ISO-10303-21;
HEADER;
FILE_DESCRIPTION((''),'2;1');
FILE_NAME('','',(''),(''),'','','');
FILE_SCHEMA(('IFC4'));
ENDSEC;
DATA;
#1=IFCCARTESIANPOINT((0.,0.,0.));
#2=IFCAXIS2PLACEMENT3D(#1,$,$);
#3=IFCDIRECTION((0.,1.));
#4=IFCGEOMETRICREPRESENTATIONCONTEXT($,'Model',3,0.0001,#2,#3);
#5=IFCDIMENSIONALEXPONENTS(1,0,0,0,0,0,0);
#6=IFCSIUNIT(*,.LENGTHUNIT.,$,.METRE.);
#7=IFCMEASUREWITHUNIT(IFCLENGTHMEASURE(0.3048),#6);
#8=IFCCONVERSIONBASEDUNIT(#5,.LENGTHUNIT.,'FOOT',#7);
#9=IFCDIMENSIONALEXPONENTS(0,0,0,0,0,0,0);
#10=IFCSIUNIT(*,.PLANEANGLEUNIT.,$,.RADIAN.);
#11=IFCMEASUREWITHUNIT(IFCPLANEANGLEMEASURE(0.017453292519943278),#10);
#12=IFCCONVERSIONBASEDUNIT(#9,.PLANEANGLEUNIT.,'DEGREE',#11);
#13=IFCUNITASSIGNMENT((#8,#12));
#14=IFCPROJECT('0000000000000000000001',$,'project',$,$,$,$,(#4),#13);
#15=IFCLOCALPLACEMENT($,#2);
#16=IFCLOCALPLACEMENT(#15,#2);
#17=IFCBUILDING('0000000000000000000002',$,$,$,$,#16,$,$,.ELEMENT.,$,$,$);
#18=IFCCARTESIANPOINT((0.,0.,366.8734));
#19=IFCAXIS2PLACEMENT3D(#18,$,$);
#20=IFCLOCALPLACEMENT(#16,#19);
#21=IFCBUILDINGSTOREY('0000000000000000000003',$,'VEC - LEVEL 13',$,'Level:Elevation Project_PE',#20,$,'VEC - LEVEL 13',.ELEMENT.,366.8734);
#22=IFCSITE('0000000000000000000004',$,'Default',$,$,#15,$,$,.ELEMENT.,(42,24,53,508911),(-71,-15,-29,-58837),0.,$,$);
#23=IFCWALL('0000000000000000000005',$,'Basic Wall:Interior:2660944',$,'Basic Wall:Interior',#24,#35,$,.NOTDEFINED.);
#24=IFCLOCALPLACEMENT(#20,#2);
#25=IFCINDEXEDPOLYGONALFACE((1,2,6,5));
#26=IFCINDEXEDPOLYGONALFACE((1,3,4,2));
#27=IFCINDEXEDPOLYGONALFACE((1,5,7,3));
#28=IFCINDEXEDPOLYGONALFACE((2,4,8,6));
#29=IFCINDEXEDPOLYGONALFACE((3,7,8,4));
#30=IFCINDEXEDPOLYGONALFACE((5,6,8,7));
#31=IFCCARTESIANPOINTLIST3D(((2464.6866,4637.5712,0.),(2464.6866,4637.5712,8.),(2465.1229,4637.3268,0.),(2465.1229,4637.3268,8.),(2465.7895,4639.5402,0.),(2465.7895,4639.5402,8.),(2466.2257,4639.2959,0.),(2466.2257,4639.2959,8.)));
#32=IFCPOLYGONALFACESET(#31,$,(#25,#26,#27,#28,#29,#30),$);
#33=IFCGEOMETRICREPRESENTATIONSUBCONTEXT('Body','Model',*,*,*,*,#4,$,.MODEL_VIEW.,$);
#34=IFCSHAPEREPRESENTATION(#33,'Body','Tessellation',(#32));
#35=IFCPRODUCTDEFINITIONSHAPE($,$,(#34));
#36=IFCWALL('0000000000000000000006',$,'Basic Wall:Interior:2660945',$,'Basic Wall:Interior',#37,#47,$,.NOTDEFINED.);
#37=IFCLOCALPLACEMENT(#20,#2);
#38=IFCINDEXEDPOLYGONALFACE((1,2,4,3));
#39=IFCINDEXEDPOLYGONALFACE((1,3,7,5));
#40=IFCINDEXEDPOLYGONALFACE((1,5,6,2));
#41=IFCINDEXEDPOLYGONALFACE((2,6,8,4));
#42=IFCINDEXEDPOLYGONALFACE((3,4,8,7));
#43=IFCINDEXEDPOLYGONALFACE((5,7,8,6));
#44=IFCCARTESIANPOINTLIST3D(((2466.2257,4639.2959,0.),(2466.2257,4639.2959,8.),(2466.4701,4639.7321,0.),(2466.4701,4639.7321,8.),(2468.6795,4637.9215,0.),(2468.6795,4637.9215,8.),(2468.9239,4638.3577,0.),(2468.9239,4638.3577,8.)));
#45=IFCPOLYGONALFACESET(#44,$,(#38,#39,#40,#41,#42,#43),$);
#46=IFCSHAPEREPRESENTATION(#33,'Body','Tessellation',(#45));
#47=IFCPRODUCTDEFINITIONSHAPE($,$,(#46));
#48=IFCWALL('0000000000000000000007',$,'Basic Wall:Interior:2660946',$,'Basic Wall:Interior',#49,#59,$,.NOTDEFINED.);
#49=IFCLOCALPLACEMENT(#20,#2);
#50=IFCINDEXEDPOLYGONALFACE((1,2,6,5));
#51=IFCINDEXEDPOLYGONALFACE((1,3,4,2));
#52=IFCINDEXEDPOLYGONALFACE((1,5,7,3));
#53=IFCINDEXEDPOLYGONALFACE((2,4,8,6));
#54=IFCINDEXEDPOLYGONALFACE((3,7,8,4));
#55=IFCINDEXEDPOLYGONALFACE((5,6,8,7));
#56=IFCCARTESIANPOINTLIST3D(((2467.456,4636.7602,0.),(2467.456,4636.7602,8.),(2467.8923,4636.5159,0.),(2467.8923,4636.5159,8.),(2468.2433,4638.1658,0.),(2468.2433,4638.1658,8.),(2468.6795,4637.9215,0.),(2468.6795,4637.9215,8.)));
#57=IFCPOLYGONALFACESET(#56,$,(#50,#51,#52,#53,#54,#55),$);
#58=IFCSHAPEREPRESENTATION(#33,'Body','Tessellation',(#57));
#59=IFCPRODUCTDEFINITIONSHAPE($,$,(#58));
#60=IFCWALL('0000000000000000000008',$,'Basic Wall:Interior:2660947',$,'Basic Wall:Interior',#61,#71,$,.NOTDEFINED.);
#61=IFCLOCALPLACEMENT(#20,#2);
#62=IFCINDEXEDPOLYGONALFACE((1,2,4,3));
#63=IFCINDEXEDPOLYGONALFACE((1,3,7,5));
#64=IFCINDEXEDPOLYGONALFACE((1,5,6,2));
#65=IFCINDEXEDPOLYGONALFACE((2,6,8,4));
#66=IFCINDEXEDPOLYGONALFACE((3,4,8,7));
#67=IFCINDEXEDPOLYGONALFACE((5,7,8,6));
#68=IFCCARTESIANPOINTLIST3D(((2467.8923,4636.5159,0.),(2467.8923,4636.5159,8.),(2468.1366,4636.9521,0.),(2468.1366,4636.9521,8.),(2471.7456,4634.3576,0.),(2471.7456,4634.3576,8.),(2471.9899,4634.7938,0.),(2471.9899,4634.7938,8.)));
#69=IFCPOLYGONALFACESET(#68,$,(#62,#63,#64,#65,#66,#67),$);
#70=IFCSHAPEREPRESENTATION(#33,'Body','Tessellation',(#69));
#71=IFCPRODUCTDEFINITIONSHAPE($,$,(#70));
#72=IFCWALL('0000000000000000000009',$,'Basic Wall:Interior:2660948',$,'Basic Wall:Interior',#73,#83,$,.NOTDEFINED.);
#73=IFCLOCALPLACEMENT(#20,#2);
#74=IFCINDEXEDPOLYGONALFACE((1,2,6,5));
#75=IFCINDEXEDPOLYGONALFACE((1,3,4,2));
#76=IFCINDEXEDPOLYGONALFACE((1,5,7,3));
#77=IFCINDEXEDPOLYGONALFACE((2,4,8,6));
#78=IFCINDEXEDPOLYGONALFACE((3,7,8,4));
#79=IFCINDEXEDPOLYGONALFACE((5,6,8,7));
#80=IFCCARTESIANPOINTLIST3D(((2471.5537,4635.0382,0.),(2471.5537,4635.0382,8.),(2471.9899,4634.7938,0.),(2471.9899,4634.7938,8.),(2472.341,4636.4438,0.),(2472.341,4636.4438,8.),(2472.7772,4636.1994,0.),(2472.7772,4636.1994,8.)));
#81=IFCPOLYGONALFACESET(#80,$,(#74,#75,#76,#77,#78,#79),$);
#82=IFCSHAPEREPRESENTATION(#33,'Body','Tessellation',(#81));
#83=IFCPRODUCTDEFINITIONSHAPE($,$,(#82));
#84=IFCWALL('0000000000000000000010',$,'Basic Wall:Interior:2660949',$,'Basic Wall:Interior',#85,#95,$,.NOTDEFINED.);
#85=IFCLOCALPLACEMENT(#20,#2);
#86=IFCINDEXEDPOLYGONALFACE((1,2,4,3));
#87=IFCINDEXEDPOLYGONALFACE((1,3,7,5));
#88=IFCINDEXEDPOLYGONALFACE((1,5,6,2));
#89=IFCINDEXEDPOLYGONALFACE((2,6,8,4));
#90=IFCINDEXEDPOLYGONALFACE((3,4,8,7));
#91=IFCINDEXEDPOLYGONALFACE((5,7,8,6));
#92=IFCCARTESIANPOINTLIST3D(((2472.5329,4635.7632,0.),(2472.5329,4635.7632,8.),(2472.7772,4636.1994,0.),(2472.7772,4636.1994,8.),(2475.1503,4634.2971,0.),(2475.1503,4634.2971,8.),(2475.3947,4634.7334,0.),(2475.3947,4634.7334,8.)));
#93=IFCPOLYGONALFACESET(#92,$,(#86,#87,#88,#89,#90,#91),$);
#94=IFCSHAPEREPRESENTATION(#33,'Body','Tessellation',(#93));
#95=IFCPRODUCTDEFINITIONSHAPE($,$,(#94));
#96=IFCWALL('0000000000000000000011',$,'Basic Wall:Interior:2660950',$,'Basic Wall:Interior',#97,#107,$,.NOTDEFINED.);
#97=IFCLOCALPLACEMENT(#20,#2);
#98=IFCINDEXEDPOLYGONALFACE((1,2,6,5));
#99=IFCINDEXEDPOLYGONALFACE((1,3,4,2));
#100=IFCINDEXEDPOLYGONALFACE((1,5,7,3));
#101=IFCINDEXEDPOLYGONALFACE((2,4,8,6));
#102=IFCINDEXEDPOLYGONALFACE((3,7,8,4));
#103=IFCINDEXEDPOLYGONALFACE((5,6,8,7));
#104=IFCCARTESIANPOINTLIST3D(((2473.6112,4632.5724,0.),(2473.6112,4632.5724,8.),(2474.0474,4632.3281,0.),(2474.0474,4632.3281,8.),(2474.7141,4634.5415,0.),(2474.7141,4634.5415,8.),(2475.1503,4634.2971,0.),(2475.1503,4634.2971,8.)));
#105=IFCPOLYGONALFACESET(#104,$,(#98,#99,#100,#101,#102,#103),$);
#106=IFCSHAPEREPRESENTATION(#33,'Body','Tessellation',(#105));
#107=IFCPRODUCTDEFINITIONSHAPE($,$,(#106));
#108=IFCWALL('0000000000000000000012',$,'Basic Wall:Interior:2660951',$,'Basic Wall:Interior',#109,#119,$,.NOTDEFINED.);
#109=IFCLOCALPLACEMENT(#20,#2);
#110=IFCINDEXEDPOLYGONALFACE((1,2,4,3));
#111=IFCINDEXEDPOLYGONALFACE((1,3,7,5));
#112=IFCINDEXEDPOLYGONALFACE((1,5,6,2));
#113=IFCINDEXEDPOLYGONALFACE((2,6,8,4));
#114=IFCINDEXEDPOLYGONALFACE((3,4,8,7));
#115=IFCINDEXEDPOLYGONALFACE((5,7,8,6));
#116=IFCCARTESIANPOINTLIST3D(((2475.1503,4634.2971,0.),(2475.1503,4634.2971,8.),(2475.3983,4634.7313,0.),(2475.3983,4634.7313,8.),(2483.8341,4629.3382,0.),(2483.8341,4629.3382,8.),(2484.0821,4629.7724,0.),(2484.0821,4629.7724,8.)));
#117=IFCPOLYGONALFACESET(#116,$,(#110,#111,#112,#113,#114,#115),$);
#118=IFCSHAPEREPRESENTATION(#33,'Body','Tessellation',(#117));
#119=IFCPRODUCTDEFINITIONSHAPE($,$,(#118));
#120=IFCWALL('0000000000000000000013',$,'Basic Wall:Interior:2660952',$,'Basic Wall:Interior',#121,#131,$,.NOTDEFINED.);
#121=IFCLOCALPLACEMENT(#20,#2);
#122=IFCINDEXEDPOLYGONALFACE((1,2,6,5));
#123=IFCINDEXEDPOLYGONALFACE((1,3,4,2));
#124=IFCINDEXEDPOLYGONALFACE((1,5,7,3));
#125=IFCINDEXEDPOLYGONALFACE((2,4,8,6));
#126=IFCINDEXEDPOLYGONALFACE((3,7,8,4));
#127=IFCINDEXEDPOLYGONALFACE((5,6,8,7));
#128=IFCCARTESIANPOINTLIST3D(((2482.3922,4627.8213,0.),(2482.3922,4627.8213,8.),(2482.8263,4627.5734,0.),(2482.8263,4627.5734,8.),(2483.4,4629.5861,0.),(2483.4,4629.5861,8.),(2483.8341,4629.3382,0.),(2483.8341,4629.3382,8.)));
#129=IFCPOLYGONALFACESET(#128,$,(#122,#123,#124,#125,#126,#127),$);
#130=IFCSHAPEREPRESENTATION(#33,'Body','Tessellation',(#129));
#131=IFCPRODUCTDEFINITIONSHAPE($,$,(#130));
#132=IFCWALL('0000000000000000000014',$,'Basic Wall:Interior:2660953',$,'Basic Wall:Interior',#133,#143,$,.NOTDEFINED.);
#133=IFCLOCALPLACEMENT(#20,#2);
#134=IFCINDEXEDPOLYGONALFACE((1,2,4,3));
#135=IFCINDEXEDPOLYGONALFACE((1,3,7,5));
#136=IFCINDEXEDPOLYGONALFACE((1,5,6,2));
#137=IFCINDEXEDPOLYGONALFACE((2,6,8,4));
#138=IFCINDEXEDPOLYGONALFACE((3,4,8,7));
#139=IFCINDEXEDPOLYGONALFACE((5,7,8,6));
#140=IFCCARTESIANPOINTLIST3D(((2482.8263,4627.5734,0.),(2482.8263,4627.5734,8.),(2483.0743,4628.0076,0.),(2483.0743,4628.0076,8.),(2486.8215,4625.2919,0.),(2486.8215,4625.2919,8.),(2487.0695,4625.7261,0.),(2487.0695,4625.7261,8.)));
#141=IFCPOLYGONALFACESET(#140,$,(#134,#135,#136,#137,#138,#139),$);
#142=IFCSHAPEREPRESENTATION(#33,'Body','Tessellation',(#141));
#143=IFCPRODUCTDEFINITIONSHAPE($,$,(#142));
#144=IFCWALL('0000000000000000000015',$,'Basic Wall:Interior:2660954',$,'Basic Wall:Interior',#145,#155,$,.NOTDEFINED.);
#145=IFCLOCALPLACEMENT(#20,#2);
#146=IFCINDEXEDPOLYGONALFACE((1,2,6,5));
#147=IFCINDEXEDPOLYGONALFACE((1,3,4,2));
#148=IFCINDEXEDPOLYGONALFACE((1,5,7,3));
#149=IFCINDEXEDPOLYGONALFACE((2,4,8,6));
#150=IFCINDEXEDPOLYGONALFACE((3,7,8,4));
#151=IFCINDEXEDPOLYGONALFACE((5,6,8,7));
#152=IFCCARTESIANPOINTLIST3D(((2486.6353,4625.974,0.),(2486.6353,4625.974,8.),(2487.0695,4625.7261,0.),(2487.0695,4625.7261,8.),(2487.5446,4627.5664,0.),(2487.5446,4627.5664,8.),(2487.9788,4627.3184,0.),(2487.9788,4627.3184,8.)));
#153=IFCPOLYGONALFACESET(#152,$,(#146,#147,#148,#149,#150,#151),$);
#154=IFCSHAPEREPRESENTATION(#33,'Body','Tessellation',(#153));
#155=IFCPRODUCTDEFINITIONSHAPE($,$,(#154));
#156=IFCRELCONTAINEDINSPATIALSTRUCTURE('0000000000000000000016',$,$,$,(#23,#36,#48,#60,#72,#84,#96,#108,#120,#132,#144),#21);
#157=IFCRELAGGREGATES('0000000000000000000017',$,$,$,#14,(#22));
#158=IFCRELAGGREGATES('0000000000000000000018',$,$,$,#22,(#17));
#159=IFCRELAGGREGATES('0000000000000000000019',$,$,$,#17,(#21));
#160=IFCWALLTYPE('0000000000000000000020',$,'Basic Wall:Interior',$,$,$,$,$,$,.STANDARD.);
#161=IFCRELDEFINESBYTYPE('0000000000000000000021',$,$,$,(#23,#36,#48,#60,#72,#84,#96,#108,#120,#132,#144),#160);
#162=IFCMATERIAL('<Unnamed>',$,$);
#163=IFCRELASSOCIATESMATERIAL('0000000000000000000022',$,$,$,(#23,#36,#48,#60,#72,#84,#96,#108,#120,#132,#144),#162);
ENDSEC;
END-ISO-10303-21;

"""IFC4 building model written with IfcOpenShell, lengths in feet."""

from ifc_helpers import new_model, entity, si_unit, converted_unit, direction, frame, origin, place, context, subcontext, project, spatial, indexed_curve, outline, extrude, material, type_object, element, save


model = new_model("IFC4")

# Units and contexts
model_context = context("Model", 3, precision=0.0001, world=origin(), true_north=direction((0.0, 1.0)))
body_context = subcontext(model_context, "Body", "Model", "MODEL_VIEW")
ifc_project = project(units=[converted_unit("LENGTHUNIT", "FOOT", entity("IfcLengthMeasure", 0.3048), si_unit("LENGTHUNIT", "METRE"), dimensions=[1, 0, 0, 0, 0, 0, 0]), converted_unit("PLANEANGLEUNIT", "DEGREE", entity("IfcPlaneAngleMeasure", 0.017453292519943278), si_unit("PLANEANGLEUNIT", "RADIAN"), dimensions=[0, 0, 0, 0, 0, 0, 0])], contexts=[model_context])

# Site, building, storey
site_placement = place(None, origin())
site = spatial("IfcSite", under=ifc_project, at=site_placement, Name="Default", CompositionType="ELEMENT", RefLatitude=(42, 24, 53, 508911), RefLongitude=(-71, -15, -29, -58837), RefElevation=0.0)
building_placement = place(site_placement, origin())
building = spatial("IfcBuilding", under=site, at=building_placement, CompositionType="ELEMENT")
storey_placement = place(building_placement, frame((0.0, 0.0, 366.8734)))
storey = spatial("IfcBuildingStorey", under=building, at=storey_placement, Name="VEC - LEVEL 13", ObjectType="Level:Elevation Project_PE", LongName="VEC - LEVEL 13", CompositionType="ELEMENT", Elevation=366.8734)

# Walls
ifc_material_1 = material(Name="<Unnamed>")
wall_type = type_object("IfcWallType", Name="Basic Wall:Interior", PredefinedType="STANDARD")
wall_1_placement = place(storey_placement, frame((2466.0076, 4639.418, 0.0), z_axis=(0.0, 0.0, 1.0), x_axis=(-0.488675, -0.872466, 0.0)))
element("IfcWall", 1, at=wall_1_placement, inside=storey, type_object=wall_type, material=ifc_material_1, Name="Basic Wall:Interior:2660944", ObjectType="Basic Wall:Interior", PredefinedType="NOTDEFINED", context=body_context, shape_type="SweptSolid", body=[
    extrude(outline(indexed_curve([(2.2569, 0.25), (0.0, 0.25), (0.0, -0.25), (2.2569, -0.25), (2.2569, 0.25)], self_intersect=False)), origin(), (0.0, 0.0, 1.0), 8.0),
])
wall_2_placement = place(storey_placement, frame((2466.3479, 4639.514, 0.0), z_axis=(0.0, 0.0, 1.0), x_axis=(0.872466, -0.488675, 0.0)))
element("IfcWall", 2, at=wall_2_placement, inside=storey, type_object=wall_type, material=ifc_material_1, Name="Basic Wall:Interior:2660945", ObjectType="Basic Wall:Interior", PredefinedType="NOTDEFINED", context=body_context, shape_type="SweptSolid", body=[
    extrude(outline(indexed_curve([(2.8125, 0.25), (0.0, 0.25), (0.0, -0.25), (2.8125, -0.25), (2.8125, 0.25)], self_intersect=False)), origin(), (0.0, 0.0, 1.0), 8.0),
])
wall_3_placement = place(storey_placement, frame((2468.4614, 4638.0436, 0.0), z_axis=(0.0, 0.0, 1.0), x_axis=(-0.488675, -0.872466, 0.0)))
element("IfcWall", 3, at=wall_3_placement, inside=storey, type_object=wall_type, material=ifc_material_1, Name="Basic Wall:Interior:2660946", ObjectType="Basic Wall:Interior", PredefinedType="NOTDEFINED", context=body_context, shape_type="SweptSolid", body=[
    extrude(outline(indexed_curve([(1.611, 0.25), (0.0, 0.25), (0.0, -0.25), (1.611, -0.25), (1.611, 0.25)], self_intersect=False)), origin(), (0.0, 0.0, 1.0), 8.0),
])
wall_4_placement = place(storey_placement, frame((2468.0144, 4636.734, 0.0), z_axis=(0.0, 0.0, 1.0), x_axis=(0.872466, -0.488675, 0.0)))
element("IfcWall", 4, at=wall_4_placement, inside=storey, type_object=wall_type, material=ifc_material_1, Name="Basic Wall:Interior:2660947", ObjectType="Basic Wall:Interior", PredefinedType="NOTDEFINED", context=body_context, shape_type="SweptSolid", body=[
    extrude(outline(indexed_curve([(4.4166, 0.25), (0.0, 0.25), (0.0, -0.25), (4.4166, -0.25), (4.4166, 0.25)], self_intersect=False)), origin(), (0.0, 0.0, 1.0), 8.0),
])
wall_5_placement = place(storey_placement, frame((2471.7718, 4634.916, 0.0), z_axis=(0.0, 0.0, 1.0), x_axis=(0.488675, 0.872466, 0.0)))
element("IfcWall", 5, at=wall_5_placement, inside=storey, type_object=wall_type, material=ifc_material_1, Name="Basic Wall:Interior:2660948", ObjectType="Basic Wall:Interior", PredefinedType="NOTDEFINED", context=body_context, shape_type="SweptSolid", body=[
    extrude(outline(indexed_curve([(1.611, 0.25), (0.0, 0.25), (0.0, -0.25), (1.611, -0.25), (1.611, 0.25)], self_intersect=False)), origin(), (0.0, 0.0, 1.0), 8.0),
])
wall_6_placement = place(storey_placement, frame((2472.655, 4635.9813, 0.0), z_axis=(0.0, 0.0, 1.0), x_axis=(0.872466, -0.488675, 0.0)))
element("IfcWall", 6, at=wall_6_placement, inside=storey, type_object=wall_type, material=ifc_material_1, Name="Basic Wall:Interior:2660949", ObjectType="Basic Wall:Interior", PredefinedType="NOTDEFINED", context=body_context, shape_type="SweptSolid", body=[
    extrude(outline(indexed_curve([(3.0001, 0.25), (0.0, 0.25), (0.0, -0.25), (3.0001, -0.25), (3.0001, 0.25)], self_intersect=False)), origin(), (0.0, 0.0, 1.0), 8.0),
])
wall_7_placement = place(storey_placement, frame((2474.9322, 4634.4193, 0.0), z_axis=(0.0, 0.0, 1.0), x_axis=(-0.488675, -0.872466, 0.0)))
element("IfcWall", 7, at=wall_7_placement, inside=storey, type_object=wall_type, material=ifc_material_1, Name="Basic Wall:Interior:2660950", ObjectType="Basic Wall:Interior", PredefinedType="NOTDEFINED", context=body_context, shape_type="SweptSolid", body=[
    extrude(outline(indexed_curve([(2.2569, 0.25), (0.0, 0.25), (0.0, -0.25), (2.2569, -0.25), (2.2569, 0.25)], self_intersect=False)), origin(), (0.0, 0.0, 1.0), 8.0),
])
wall_8_placement = place(storey_placement, frame((2475.2743, 4634.5142, 0.0), z_axis=(0.0, 0.0, 1.0), x_axis=(0.868382, -0.495895, 0.0)))
element("IfcWall", 8, at=wall_8_placement, inside=storey, type_object=wall_type, material=ifc_material_1, Name="Basic Wall:Interior:2660951", ObjectType="Basic Wall:Interior", PredefinedType="NOTDEFINED", context=body_context, shape_type="SweptSolid", body=[
    extrude(outline(indexed_curve([(10.0, 0.25), (0.0, 0.25), (0.0, -0.25), (10.0, -0.25), (10.0, 0.25)], self_intersect=False)), origin(), (0.0, 0.0, 1.0), 8.0),
])
wall_9_placement = place(storey_placement, frame((2483.617, 4629.4622, 0.0), z_axis=(0.0, 0.0, 1.0), x_axis=(-0.495895, -0.868382, 0.0)))
element("IfcWall", 9, at=wall_9_placement, inside=storey, type_object=wall_type, material=ifc_material_1, Name="Basic Wall:Interior:2660952", ObjectType="Basic Wall:Interior", PredefinedType="NOTDEFINED", context=body_context, shape_type="SweptSolid", body=[
    extrude(outline(indexed_curve([(2.0323, 0.25), (0.0, 0.25), (0.0, -0.25), (2.0323, -0.25), (2.0323, 0.25)], self_intersect=False)), origin(), (0.0, 0.0, 1.0), 8.0),
])
wall_10_placement = place(storey_placement, frame((2482.9503, 4627.7905, 0.0), z_axis=(0.0, 0.0, 1.0), x_axis=(0.868382, -0.495895, 0.0)))
element("IfcWall", 10, at=wall_10_placement, inside=storey, type_object=wall_type, material=ifc_material_1, Name="Basic Wall:Interior:2660953", ObjectType="Basic Wall:Interior", PredefinedType="NOTDEFINED", context=body_context, shape_type="SweptSolid", body=[
    extrude(outline(indexed_curve([(4.6007, 0.25), (0.0, 0.25), (0.0, -0.25), (4.6007, -0.25), (4.6007, 0.25)], self_intersect=False)), origin(), (0.0, 0.0, 1.0), 8.0),
])
wall_11_placement = place(storey_placement, frame((2486.8524, 4625.8501, 0.0), z_axis=(0.0, 0.0, 1.0), x_axis=(0.495895, 0.868382, 0.0)))
element("IfcWall", 11, at=wall_11_placement, inside=storey, type_object=wall_type, material=ifc_material_1, Name="Basic Wall:Interior:2660954", ObjectType="Basic Wall:Interior", PredefinedType="NOTDEFINED", context=body_context, shape_type="SweptSolid", body=[
    extrude(outline(indexed_curve([(1.8337, 0.25), (0.0, 0.25), (0.0, -0.25), (1.8337, -0.25), (1.8337, 0.25)], self_intersect=False)), origin(), (0.0, 0.0, 1.0), 8.0),
])

save(model, "model.ifc")
